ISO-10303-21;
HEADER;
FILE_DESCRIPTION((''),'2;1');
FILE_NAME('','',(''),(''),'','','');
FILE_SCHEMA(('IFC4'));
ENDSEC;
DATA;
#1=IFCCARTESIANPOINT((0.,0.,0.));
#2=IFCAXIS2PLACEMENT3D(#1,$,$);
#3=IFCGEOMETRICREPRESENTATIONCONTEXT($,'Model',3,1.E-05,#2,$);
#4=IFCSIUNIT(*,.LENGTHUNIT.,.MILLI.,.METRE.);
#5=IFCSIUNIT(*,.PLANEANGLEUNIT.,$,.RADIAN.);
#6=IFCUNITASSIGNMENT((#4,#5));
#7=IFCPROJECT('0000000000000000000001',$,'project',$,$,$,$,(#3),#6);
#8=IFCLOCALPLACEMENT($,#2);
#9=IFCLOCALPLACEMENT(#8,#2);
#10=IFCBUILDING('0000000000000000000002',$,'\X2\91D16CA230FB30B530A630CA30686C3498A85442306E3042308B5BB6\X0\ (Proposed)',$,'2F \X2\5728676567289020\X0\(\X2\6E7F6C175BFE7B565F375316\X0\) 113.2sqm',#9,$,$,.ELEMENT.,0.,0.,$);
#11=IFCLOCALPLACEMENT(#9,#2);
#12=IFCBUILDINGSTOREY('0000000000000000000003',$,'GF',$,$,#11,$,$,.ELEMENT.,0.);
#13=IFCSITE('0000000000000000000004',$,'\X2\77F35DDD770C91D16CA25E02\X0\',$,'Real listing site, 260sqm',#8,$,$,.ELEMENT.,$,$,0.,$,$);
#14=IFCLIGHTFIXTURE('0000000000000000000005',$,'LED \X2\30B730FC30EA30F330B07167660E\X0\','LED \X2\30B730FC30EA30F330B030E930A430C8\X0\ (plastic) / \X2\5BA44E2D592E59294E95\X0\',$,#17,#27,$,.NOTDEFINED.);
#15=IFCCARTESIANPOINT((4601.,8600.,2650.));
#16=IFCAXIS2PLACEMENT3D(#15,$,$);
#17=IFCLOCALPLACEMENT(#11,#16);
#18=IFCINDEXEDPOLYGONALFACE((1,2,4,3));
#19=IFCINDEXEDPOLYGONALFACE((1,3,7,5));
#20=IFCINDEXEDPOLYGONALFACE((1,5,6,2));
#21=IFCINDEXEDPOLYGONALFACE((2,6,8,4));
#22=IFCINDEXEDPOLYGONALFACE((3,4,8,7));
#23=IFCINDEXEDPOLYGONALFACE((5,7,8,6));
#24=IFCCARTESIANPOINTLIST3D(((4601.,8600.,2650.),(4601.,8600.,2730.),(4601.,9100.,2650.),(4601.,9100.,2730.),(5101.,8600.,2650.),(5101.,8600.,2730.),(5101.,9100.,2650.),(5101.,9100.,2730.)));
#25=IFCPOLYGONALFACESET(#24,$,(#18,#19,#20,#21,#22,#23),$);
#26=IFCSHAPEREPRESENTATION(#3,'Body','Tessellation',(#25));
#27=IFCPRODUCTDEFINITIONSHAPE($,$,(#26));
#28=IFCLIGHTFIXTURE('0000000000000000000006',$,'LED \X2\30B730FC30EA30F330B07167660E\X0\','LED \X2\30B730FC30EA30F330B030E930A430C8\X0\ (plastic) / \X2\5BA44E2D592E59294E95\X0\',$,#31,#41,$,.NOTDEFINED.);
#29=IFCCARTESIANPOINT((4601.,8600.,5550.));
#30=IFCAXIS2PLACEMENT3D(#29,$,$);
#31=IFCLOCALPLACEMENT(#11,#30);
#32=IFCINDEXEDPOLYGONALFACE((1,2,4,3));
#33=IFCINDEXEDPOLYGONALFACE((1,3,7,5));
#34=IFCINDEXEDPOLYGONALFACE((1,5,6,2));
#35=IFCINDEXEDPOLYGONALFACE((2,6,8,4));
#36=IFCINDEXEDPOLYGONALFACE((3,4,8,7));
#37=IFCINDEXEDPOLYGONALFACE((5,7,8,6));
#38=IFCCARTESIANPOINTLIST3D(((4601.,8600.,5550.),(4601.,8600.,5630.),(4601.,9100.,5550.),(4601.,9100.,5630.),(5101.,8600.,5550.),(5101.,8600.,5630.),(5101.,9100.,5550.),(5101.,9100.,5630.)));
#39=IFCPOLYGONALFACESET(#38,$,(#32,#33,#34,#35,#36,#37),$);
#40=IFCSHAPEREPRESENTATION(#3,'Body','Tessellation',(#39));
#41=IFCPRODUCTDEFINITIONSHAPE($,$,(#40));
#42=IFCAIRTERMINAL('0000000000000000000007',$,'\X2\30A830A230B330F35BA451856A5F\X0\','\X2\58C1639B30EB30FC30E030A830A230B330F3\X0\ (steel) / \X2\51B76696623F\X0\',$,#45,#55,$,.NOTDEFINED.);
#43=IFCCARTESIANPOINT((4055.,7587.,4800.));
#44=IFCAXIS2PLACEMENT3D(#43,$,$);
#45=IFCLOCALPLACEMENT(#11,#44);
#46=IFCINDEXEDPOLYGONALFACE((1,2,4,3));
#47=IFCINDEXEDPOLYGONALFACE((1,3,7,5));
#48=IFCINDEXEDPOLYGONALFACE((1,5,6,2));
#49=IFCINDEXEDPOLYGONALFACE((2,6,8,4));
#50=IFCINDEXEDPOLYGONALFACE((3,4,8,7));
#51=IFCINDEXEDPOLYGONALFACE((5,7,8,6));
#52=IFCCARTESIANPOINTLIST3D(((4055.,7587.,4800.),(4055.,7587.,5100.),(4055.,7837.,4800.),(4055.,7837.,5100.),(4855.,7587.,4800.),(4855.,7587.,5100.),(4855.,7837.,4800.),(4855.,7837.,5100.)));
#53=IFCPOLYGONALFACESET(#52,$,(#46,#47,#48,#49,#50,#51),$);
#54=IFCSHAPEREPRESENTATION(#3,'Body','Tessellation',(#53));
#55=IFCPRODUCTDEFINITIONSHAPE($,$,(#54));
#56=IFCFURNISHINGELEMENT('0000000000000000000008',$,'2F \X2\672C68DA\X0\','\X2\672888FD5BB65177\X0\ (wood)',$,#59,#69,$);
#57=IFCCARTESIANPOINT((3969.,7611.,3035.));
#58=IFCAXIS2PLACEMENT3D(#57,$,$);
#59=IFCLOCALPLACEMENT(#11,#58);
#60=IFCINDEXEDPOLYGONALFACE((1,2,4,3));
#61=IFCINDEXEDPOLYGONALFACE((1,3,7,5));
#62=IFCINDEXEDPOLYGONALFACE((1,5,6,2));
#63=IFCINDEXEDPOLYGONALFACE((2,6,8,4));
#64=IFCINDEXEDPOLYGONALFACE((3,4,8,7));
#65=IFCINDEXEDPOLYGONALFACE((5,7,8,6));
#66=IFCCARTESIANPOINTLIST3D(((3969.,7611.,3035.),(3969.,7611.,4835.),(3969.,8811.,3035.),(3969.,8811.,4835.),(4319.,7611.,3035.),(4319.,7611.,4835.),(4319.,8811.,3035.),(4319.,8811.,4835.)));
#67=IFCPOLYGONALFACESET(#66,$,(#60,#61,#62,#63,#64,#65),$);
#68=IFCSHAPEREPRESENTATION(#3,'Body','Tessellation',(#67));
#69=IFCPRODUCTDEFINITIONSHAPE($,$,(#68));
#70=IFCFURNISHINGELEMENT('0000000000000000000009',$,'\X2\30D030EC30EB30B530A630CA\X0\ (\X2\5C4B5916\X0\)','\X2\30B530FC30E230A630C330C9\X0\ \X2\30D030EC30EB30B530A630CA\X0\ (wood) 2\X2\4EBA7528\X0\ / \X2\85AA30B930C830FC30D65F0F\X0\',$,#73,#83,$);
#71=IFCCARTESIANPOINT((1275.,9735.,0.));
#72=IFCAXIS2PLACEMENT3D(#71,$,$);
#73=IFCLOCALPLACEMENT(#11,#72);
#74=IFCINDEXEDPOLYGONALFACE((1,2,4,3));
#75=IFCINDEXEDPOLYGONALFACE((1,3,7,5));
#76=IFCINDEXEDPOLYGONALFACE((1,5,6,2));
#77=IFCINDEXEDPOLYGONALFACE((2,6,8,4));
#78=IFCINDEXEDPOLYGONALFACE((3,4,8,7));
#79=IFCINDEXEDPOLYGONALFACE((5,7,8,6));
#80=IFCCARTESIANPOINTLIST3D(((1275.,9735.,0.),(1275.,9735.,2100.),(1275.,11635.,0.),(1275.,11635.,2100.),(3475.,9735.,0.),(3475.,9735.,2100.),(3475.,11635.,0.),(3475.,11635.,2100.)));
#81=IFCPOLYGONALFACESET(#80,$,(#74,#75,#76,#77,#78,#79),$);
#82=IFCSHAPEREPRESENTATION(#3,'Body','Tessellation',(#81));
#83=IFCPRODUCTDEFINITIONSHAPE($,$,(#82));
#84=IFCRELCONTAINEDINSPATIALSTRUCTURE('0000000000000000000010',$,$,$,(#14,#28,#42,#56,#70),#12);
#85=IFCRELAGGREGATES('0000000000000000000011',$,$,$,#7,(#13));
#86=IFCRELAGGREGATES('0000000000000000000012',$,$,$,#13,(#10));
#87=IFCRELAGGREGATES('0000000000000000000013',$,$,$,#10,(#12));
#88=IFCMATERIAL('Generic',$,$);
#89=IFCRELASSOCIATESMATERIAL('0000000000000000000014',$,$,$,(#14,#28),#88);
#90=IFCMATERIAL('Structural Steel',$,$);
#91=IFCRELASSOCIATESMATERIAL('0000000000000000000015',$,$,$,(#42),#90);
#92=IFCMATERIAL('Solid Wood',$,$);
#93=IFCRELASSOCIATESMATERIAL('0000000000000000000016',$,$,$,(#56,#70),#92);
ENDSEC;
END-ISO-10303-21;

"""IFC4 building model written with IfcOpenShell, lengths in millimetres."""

from ifc_helpers import new_model, si_unit, frame, frame_2d, origin, place, context, project, spatial, rectangle, extrude, material, element, save


model = new_model("IFC4")

# Units and contexts
model_context = context("Model", 3, precision=1e-05, world=origin())
ifc_project = project(units=[si_unit("LENGTHUNIT", "METRE", prefix="MILLI"), si_unit("PLANEANGLEUNIT", "RADIAN")], contexts=[model_context])

# Site, building, storey
site_placement = place(None, origin())
site = spatial("IfcSite", under=ifc_project, at=site_placement, Name="石川県金沢市", ObjectType="Real listing site, 260sqm", CompositionType="ELEMENT", RefElevation=0.0)
building_placement = place(site_placement, origin())
building = spatial("IfcBuilding", under=site, at=building_placement, Name="金沢・サウナと水風呂のある家 (Proposed)", ObjectType="2F 在来木造(湿気対策強化) 113.2sqm", CompositionType="ELEMENT", ElevationOfRefHeight=0.0, ElevationOfTerrain=0.0)
storey_placement = place(building_placement, origin())
storey = spatial("IfcBuildingStorey", under=building, at=storey_placement, Name="GF", CompositionType="ELEMENT", Elevation=0.0)

# Shared definitions
ifc_material_1 = material(Name="Solid Wood")

# Shared definitions
ifc_material_2 = material(Name="Structural Steel")

# Shared definitions
ifc_material_3 = material(Name="Generic")

# Light fixtures
light_fixture_1_placement = place(storey_placement, frame((4601.0, 8600.0, 2650.0)))
element("IfcLightFixture", 1, at=light_fixture_1_placement, inside=storey, material=ifc_material_3, Name="LED シーリング照明", Description="LED シーリングライト (plastic) / 室中央天井", PredefinedType="NOTDEFINED", context=model_context, shape_type="SweptSolid", body=[
    extrude(rectangle(XDim=500.0, YDim=500.0, at=frame_2d((250.0, 250.0))), frame((4601.0, 8600.0, 2650.0)), (0.0, 0.0, 1.0), 80.0),
])
light_fixture_2_placement = place(storey_placement, frame((4601.0, 8600.0, 5550.0)))
element("IfcLightFixture", 2, at=light_fixture_2_placement, inside=storey, material=ifc_material_3, Name="LED シーリング照明", Description="LED シーリングライト (plastic) / 室中央天井", PredefinedType="NOTDEFINED", context=model_context, shape_type="SweptSolid", body=[
    extrude(rectangle(XDim=500.0, YDim=500.0, at=frame_2d((250.0, 250.0))), frame((4601.0, 8600.0, 5550.0)), (0.0, 0.0, 1.0), 80.0),
])

# Air terminal
air_terminal_placement = place(storey_placement, frame((4055.0, 7587.0, 4800.0)))
element("IfcAirTerminal", 3, at=air_terminal_placement, inside=storey, material=ifc_material_2, Name="エアコン室内機", Description="壁掛ルームエアコン (steel) / 冷暖房", PredefinedType="NOTDEFINED", context=model_context, shape_type="SweptSolid", body=[
    extrude(rectangle(XDim=800.0, YDim=250.0, at=frame_2d((400.0, 125.0))), frame((4055.0, 7587.0, 4800.0)), (0.0, 0.0, 1.0), 300.0),
])

# Furnishing elements
furnishing_1_placement = place(storey_placement, frame((3969.0, 7611.0, 3035.0)))
element("IfcFurnishingElement", 4, at=furnishing_1_placement, inside=storey, material=ifc_material_1, Name="2F 本棚", Description="木製家具 (wood)", context=model_context, shape_type="SweptSolid", body=[
    extrude(rectangle(XDim=350.0, YDim=1200.0, at=frame_2d((175.0, 600.0))), frame((3969.0, 7611.0, 3035.0)), (0.0, 0.0, 1.0), 1800.0),
])
furnishing_2_placement = place(storey_placement, frame((1275.0, 9735.0, 0.0)))
element("IfcFurnishingElement", 5, at=furnishing_2_placement, inside=storey, material=ifc_material_1, Name="バレルサウナ (屋外)", Description="サーモウッド バレルサウナ (wood) 2人用 / 薪ストーブ式", context=model_context, shape_type="SweptSolid", body=[
    extrude(rectangle(XDim=2200.0, YDim=1900.0, at=frame_2d((1100.0, 950.0))), frame((1275.0, 9735.0, 0.0)), (0.0, 0.0, 1.0), 2100.0),
])

save(model, "model.ifc")
